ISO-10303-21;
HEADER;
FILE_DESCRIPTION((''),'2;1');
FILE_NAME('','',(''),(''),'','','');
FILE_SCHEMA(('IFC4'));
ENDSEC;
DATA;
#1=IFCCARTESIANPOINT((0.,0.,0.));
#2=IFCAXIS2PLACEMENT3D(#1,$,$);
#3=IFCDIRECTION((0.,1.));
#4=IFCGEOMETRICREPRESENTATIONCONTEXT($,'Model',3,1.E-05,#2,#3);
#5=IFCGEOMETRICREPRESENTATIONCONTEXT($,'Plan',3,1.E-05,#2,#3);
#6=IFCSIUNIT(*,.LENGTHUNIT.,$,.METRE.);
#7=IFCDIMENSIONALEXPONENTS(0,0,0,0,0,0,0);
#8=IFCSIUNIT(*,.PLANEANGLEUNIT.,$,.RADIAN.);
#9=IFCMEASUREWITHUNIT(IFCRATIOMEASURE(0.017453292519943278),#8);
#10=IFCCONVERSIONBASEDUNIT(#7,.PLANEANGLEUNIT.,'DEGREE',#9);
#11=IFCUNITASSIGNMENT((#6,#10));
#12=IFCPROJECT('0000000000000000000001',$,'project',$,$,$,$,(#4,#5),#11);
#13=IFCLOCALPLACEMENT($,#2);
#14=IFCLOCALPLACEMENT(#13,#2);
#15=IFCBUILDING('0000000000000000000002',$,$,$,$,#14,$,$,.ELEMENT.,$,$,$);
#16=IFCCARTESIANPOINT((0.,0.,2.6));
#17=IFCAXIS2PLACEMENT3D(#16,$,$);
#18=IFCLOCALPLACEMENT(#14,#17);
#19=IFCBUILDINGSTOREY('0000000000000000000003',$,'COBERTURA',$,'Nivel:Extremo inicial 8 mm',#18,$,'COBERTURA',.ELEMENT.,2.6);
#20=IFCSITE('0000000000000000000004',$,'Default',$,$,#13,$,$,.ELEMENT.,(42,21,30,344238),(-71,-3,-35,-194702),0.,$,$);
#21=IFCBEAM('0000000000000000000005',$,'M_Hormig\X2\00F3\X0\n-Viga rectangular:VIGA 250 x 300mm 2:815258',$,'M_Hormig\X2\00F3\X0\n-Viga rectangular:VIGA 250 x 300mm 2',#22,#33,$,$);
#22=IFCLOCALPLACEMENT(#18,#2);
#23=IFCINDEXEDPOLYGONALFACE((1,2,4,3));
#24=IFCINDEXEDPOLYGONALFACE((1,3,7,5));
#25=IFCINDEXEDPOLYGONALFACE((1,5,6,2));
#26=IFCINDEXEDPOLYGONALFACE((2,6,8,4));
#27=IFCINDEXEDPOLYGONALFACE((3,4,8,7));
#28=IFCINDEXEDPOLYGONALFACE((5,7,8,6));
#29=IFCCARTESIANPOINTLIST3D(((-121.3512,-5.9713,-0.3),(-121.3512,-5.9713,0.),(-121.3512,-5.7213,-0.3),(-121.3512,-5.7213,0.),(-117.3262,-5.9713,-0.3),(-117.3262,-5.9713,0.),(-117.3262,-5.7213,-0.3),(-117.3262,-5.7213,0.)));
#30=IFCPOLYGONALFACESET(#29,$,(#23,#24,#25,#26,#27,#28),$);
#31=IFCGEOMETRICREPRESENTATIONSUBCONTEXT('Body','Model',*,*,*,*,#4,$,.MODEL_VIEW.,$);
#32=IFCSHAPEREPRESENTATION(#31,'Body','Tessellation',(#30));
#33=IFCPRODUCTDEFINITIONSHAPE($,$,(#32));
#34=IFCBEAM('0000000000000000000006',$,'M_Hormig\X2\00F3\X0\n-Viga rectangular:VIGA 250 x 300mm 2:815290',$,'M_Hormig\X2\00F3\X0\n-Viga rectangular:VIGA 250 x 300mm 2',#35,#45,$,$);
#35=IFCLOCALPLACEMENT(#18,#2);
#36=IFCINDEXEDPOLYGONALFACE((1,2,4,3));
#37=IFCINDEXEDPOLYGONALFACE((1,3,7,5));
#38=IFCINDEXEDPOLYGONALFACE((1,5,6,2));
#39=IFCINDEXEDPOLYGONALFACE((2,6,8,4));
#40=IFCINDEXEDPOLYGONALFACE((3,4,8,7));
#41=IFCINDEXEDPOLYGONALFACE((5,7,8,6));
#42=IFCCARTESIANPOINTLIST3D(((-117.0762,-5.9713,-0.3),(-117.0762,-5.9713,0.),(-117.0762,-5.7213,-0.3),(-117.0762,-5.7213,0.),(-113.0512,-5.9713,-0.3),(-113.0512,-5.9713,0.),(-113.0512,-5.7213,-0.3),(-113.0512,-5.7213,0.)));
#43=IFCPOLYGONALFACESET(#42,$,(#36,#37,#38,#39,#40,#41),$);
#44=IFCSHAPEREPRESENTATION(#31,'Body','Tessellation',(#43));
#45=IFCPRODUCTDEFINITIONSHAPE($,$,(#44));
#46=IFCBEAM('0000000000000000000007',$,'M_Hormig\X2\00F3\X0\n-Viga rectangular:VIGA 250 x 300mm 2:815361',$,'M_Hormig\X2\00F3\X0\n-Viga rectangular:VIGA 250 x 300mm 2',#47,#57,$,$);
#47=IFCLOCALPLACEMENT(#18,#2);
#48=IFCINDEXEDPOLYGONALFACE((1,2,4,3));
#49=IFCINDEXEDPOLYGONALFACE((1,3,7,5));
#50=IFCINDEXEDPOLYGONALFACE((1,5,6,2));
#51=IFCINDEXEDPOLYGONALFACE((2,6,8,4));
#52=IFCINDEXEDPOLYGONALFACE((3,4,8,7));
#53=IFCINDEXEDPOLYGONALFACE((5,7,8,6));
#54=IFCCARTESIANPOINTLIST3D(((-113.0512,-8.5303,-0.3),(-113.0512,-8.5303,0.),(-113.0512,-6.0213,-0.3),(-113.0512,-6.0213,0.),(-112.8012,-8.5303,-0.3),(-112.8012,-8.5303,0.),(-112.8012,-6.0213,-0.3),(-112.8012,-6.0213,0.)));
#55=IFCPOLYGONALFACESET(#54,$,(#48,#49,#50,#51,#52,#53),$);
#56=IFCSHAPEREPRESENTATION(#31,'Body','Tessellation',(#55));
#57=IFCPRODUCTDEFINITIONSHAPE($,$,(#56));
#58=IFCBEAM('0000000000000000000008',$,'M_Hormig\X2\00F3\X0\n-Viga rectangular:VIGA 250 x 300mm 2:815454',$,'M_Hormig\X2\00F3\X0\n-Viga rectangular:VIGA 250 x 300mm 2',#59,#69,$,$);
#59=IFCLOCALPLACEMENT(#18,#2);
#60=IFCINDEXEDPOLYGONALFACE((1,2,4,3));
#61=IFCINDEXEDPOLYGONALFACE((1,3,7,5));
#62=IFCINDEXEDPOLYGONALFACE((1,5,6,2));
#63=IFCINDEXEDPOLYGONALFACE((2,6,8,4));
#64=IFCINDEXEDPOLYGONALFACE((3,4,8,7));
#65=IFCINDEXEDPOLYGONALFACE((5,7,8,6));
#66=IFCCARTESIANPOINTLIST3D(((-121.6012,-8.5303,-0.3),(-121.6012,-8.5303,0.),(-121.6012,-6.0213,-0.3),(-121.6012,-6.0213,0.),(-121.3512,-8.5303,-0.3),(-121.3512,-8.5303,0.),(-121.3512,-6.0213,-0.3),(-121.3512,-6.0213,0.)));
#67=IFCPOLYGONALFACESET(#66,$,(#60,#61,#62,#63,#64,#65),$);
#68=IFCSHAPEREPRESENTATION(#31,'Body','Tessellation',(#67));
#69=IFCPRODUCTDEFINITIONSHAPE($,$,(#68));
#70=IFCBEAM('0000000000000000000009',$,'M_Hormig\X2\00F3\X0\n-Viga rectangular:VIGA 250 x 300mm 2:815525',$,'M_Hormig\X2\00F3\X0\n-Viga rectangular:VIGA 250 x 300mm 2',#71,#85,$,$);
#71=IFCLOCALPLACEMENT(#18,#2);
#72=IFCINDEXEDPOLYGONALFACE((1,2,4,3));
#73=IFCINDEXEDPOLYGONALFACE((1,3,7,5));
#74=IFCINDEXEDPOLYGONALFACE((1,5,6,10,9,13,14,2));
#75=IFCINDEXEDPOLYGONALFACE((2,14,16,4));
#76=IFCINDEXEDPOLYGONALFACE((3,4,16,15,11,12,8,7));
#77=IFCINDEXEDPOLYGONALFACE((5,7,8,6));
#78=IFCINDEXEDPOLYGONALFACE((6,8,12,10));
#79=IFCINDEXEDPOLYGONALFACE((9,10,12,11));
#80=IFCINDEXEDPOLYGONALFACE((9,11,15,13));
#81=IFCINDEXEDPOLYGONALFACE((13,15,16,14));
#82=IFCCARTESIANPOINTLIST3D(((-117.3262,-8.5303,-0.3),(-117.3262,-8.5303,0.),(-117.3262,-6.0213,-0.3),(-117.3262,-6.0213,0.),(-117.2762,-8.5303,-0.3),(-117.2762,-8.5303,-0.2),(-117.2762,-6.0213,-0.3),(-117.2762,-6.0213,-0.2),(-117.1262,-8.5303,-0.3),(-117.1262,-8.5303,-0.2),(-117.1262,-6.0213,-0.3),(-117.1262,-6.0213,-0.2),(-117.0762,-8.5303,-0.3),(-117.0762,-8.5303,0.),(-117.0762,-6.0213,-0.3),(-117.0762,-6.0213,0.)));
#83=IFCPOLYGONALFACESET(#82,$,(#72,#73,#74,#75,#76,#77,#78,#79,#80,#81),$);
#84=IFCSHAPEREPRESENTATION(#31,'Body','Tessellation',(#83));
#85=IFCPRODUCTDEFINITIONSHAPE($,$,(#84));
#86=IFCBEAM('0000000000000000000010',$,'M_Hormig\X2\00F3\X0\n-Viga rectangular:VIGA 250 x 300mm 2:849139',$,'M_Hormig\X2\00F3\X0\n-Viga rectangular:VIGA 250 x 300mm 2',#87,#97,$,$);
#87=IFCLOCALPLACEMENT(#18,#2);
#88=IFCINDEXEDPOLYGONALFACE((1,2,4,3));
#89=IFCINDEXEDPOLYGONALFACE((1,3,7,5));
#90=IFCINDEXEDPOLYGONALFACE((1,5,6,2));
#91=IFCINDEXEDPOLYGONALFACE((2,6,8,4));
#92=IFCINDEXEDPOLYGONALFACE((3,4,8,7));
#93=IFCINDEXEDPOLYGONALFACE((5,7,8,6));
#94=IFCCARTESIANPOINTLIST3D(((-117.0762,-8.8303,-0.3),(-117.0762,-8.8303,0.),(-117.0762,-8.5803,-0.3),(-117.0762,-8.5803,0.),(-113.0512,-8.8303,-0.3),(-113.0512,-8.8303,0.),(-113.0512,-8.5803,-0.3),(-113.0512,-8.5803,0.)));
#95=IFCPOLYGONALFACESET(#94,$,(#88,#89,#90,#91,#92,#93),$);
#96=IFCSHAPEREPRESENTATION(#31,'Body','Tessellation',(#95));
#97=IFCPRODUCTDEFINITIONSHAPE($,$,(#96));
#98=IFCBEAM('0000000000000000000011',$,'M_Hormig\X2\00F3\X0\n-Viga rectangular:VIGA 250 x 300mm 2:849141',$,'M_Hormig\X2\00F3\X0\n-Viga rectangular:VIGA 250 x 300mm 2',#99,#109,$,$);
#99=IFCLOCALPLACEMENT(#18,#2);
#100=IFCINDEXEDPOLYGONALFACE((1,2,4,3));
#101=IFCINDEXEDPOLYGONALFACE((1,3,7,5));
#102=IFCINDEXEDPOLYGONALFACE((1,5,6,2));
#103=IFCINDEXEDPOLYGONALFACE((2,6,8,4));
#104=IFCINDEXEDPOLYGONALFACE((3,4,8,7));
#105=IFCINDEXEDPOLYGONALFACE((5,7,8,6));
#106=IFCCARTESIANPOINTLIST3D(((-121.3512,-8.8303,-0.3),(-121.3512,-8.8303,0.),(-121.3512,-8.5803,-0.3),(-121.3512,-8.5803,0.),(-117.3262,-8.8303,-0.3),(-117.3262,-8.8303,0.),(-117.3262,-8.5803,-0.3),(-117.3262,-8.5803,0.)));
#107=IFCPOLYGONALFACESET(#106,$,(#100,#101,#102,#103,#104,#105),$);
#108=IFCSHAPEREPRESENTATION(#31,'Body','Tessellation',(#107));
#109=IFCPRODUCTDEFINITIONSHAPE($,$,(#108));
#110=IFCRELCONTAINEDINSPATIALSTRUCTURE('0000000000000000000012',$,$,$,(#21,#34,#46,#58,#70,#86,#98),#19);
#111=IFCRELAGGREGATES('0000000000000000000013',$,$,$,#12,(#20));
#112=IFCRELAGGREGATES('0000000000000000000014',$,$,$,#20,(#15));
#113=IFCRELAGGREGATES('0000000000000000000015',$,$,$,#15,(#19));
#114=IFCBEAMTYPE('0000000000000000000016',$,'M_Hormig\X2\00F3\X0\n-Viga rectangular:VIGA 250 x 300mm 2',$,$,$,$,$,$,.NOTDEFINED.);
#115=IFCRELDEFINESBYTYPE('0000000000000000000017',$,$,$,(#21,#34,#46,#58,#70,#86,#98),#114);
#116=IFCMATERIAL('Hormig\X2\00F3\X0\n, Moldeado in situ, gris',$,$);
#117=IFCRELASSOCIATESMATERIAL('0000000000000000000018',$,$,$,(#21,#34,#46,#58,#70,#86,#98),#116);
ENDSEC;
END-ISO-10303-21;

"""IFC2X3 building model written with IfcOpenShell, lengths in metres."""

from ifc_helpers import new_model, entity, si_unit, converted_unit, direction, frame, frame_2d, origin, origin_2d_with_axis, place, context, subcontext, project, spatial, polyline, rectangle, outline, extrude, material, type_object, element, save


model = new_model("IFC2X3")

# Units and contexts
model_context = context("Model", 3, precision=1e-05, world=origin(), true_north=direction((0.0, 1.0)))
plan_context = context("Plan", 3, precision=1e-05, world=origin(), true_north=direction((0.0, 1.0)))
body_context = subcontext(model_context, "Body", "Model", "MODEL_VIEW")
ifc_project = project(units=[si_unit("LENGTHUNIT", "METRE"), converted_unit("PLANEANGLEUNIT", "DEGREE", entity("IfcRatioMeasure", 0.017453292519943278), si_unit("PLANEANGLEUNIT", "RADIAN"), dimensions=[0, 0, 0, 0, 0, 0, 0])], contexts=[model_context, plan_context])

# Site, building, storey
site_placement = place(None, origin())
site = spatial("IfcSite", under=ifc_project, at=site_placement, Name="Default", CompositionType="ELEMENT", RefLatitude=(42, 21, 30, 344238), RefLongitude=(-71, -3, -35, -194702), RefElevation=0.0)
building_placement = place(site_placement, origin())
building = spatial("IfcBuilding", under=site, at=building_placement, CompositionType="ELEMENT")
storey_placement = place(building_placement, frame((0.0, 0.0, 2.6)))
storey = spatial("IfcBuildingStorey", under=building, at=storey_placement, Name="COBERTURA", ObjectType="Nivel:Extremo inicial 8 mm", LongName="COBERTURA", CompositionType="ELEMENT", Elevation=2.6)

# Beams
ifc_material_1 = material(Name="Hormigón, Moldeado in situ, gris")
beam_type = type_object("IfcBeamType", Name="M_Hormigón-Viga rectangular:VIGA 250 x 300mm 2", PredefinedType="NOTDEFINED")
beam_1_placement = place(storey_placement, frame((-121.4762, -5.8463, 0.0)))
element("IfcBeam", 1, at=beam_1_placement, inside=storey, type_object=beam_type, material=ifc_material_1, Name="M_Hormigón-Viga rectangular:VIGA 250 x 300mm 2:815258", ObjectType="M_Hormigón-Viga rectangular:VIGA 250 x 300mm 2", context=body_context, shape_type="SweptSolid", body=[
    extrude(rectangle(XDim=0.3, YDim=0.25, at=frame_2d((0.0, 0.0), x_axis=(1.0, 0.0))), frame((0.125, 0.0, -0.15), z_axis=(1.0, 0.0, 0.0), x_axis=(0.0, 0.0, -1.0)), (0.0, 0.0, 1.0), 4.025),
])
beam_2_placement = place(storey_placement, frame((-112.9262, -5.8463, 0.0), z_axis=(0.0, 0.0, 1.0), x_axis=(-1.0, 0.0, 0.0)))
element("IfcBeam", 2, at=beam_2_placement, inside=storey, type_object=beam_type, material=ifc_material_1, Name="M_Hormigón-Viga rectangular:VIGA 250 x 300mm 2:815290", ObjectType="M_Hormigón-Viga rectangular:VIGA 250 x 300mm 2", context=body_context, shape_type="SweptSolid", body=[
    extrude(rectangle(XDim=0.3, YDim=0.25, at=frame_2d((0.0, 0.0), x_axis=(1.0, 0.0))), frame((0.125, 0.0, -0.15), z_axis=(1.0, 0.0, 0.0), x_axis=(0.0, 0.0, -1.0)), (0.0, 0.0, 1.0), 4.025),
])
beam_3_placement = place(storey_placement, frame((-112.9262, -8.6803, 0.0), z_axis=(0.0, 0.0, 1.0), x_axis=(0.0, 1.0, 0.0)))
element("IfcBeam", 3, at=beam_3_placement, inside=storey, type_object=beam_type, material=ifc_material_1, Name="M_Hormigón-Viga rectangular:VIGA 250 x 300mm 2:815361", ObjectType="M_Hormigón-Viga rectangular:VIGA 250 x 300mm 2", context=body_context, shape_type="SweptSolid", body=[
    extrude(rectangle(XDim=0.3, YDim=0.25, at=frame_2d((0.0, 0.0), x_axis=(1.0, 0.0))), frame((0.15, 0.0, -0.15), z_axis=(1.0, 0.0, 0.0), x_axis=(0.0, 0.0, -1.0)), (0.0, 0.0, 1.0), 2.5091),
])
beam_4_placement = place(storey_placement, frame((-121.4762, -5.7213, 0.0), z_axis=(0.0, 0.0, 1.0), x_axis=(0.0, -1.0, 0.0)))
element("IfcBeam", 4, at=beam_4_placement, inside=storey, type_object=beam_type, material=ifc_material_1, Name="M_Hormigón-Viga rectangular:VIGA 250 x 300mm 2:815454", ObjectType="M_Hormigón-Viga rectangular:VIGA 250 x 300mm 2", context=body_context, shape_type="SweptSolid", body=[
    extrude(rectangle(XDim=0.3, YDim=0.25, at=origin_2d_with_axis()), frame((0.3, 0.0, -0.15), z_axis=(1.0, 0.0, 0.0), x_axis=(0.0, 0.0, -1.0)), (0.0, 0.0, 1.0), 2.5091),
])
beam_5_placement = place(storey_placement, frame((-117.2012, -8.6803, 0.0), z_axis=(0.0, 0.0, 1.0), x_axis=(0.0, 1.0, 0.0)))
element("IfcBeam", 5, at=beam_5_placement, inside=storey, type_object=beam_type, material=ifc_material_1, Name="M_Hormigón-Viga rectangular:VIGA 250 x 300mm 2:815525", ObjectType="M_Hormigón-Viga rectangular:VIGA 250 x 300mm 2", context=body_context, shape_type="SweptSolid", body=[
    extrude(outline(polyline([(-0.2, -0.125), (0.1, -0.125), (0.1, -0.075), (0.0, -0.075), (0.0, 0.075), (0.1, 0.075), (0.1, 0.125), (-0.2, 0.125), (-0.2, -0.125)])), frame((0.15, 0.0, -0.2), z_axis=(1.0, 0.0, 0.0), x_axis=(0.0, 0.0, -1.0)), (0.0, 0.0, 1.0), 2.5091),
])
beam_6_placement = place(storey_placement, frame((-117.2012, -8.7053, 0.0)))
element("IfcBeam", 6, at=beam_6_placement, inside=storey, type_object=beam_type, material=ifc_material_1, Name="M_Hormigón-Viga rectangular:VIGA 250 x 300mm 2:849139", ObjectType="M_Hormigón-Viga rectangular:VIGA 250 x 300mm 2", context=body_context, shape_type="SweptSolid", body=[
    extrude(rectangle(XDim=0.3, YDim=0.25, at=frame_2d((0.0, 0.0), x_axis=(1.0, 0.0))), frame((0.125, 0.0, -0.15), z_axis=(1.0, 0.0, 0.0), x_axis=(0.0, 0.0, -1.0)), (0.0, 0.0, 1.0), 4.025),
])
beam_7_placement = place(storey_placement, frame((-121.4762, -8.7053, 0.0)))
element("IfcBeam", 7, at=beam_7_placement, inside=storey, type_object=beam_type, material=ifc_material_1, Name="M_Hormigón-Viga rectangular:VIGA 250 x 300mm 2:849141", ObjectType="M_Hormigón-Viga rectangular:VIGA 250 x 300mm 2", context=body_context, shape_type="SweptSolid", body=[
    extrude(rectangle(XDim=0.3, YDim=0.25, at=frame_2d((0.0, 0.0), x_axis=(1.0, 0.0))), frame((0.125, 0.0, -0.15), z_axis=(1.0, 0.0, 0.0), x_axis=(0.0, 0.0, -1.0)), (0.0, 0.0, 1.0), 4.025),
])

save(model, "model.ifc")
